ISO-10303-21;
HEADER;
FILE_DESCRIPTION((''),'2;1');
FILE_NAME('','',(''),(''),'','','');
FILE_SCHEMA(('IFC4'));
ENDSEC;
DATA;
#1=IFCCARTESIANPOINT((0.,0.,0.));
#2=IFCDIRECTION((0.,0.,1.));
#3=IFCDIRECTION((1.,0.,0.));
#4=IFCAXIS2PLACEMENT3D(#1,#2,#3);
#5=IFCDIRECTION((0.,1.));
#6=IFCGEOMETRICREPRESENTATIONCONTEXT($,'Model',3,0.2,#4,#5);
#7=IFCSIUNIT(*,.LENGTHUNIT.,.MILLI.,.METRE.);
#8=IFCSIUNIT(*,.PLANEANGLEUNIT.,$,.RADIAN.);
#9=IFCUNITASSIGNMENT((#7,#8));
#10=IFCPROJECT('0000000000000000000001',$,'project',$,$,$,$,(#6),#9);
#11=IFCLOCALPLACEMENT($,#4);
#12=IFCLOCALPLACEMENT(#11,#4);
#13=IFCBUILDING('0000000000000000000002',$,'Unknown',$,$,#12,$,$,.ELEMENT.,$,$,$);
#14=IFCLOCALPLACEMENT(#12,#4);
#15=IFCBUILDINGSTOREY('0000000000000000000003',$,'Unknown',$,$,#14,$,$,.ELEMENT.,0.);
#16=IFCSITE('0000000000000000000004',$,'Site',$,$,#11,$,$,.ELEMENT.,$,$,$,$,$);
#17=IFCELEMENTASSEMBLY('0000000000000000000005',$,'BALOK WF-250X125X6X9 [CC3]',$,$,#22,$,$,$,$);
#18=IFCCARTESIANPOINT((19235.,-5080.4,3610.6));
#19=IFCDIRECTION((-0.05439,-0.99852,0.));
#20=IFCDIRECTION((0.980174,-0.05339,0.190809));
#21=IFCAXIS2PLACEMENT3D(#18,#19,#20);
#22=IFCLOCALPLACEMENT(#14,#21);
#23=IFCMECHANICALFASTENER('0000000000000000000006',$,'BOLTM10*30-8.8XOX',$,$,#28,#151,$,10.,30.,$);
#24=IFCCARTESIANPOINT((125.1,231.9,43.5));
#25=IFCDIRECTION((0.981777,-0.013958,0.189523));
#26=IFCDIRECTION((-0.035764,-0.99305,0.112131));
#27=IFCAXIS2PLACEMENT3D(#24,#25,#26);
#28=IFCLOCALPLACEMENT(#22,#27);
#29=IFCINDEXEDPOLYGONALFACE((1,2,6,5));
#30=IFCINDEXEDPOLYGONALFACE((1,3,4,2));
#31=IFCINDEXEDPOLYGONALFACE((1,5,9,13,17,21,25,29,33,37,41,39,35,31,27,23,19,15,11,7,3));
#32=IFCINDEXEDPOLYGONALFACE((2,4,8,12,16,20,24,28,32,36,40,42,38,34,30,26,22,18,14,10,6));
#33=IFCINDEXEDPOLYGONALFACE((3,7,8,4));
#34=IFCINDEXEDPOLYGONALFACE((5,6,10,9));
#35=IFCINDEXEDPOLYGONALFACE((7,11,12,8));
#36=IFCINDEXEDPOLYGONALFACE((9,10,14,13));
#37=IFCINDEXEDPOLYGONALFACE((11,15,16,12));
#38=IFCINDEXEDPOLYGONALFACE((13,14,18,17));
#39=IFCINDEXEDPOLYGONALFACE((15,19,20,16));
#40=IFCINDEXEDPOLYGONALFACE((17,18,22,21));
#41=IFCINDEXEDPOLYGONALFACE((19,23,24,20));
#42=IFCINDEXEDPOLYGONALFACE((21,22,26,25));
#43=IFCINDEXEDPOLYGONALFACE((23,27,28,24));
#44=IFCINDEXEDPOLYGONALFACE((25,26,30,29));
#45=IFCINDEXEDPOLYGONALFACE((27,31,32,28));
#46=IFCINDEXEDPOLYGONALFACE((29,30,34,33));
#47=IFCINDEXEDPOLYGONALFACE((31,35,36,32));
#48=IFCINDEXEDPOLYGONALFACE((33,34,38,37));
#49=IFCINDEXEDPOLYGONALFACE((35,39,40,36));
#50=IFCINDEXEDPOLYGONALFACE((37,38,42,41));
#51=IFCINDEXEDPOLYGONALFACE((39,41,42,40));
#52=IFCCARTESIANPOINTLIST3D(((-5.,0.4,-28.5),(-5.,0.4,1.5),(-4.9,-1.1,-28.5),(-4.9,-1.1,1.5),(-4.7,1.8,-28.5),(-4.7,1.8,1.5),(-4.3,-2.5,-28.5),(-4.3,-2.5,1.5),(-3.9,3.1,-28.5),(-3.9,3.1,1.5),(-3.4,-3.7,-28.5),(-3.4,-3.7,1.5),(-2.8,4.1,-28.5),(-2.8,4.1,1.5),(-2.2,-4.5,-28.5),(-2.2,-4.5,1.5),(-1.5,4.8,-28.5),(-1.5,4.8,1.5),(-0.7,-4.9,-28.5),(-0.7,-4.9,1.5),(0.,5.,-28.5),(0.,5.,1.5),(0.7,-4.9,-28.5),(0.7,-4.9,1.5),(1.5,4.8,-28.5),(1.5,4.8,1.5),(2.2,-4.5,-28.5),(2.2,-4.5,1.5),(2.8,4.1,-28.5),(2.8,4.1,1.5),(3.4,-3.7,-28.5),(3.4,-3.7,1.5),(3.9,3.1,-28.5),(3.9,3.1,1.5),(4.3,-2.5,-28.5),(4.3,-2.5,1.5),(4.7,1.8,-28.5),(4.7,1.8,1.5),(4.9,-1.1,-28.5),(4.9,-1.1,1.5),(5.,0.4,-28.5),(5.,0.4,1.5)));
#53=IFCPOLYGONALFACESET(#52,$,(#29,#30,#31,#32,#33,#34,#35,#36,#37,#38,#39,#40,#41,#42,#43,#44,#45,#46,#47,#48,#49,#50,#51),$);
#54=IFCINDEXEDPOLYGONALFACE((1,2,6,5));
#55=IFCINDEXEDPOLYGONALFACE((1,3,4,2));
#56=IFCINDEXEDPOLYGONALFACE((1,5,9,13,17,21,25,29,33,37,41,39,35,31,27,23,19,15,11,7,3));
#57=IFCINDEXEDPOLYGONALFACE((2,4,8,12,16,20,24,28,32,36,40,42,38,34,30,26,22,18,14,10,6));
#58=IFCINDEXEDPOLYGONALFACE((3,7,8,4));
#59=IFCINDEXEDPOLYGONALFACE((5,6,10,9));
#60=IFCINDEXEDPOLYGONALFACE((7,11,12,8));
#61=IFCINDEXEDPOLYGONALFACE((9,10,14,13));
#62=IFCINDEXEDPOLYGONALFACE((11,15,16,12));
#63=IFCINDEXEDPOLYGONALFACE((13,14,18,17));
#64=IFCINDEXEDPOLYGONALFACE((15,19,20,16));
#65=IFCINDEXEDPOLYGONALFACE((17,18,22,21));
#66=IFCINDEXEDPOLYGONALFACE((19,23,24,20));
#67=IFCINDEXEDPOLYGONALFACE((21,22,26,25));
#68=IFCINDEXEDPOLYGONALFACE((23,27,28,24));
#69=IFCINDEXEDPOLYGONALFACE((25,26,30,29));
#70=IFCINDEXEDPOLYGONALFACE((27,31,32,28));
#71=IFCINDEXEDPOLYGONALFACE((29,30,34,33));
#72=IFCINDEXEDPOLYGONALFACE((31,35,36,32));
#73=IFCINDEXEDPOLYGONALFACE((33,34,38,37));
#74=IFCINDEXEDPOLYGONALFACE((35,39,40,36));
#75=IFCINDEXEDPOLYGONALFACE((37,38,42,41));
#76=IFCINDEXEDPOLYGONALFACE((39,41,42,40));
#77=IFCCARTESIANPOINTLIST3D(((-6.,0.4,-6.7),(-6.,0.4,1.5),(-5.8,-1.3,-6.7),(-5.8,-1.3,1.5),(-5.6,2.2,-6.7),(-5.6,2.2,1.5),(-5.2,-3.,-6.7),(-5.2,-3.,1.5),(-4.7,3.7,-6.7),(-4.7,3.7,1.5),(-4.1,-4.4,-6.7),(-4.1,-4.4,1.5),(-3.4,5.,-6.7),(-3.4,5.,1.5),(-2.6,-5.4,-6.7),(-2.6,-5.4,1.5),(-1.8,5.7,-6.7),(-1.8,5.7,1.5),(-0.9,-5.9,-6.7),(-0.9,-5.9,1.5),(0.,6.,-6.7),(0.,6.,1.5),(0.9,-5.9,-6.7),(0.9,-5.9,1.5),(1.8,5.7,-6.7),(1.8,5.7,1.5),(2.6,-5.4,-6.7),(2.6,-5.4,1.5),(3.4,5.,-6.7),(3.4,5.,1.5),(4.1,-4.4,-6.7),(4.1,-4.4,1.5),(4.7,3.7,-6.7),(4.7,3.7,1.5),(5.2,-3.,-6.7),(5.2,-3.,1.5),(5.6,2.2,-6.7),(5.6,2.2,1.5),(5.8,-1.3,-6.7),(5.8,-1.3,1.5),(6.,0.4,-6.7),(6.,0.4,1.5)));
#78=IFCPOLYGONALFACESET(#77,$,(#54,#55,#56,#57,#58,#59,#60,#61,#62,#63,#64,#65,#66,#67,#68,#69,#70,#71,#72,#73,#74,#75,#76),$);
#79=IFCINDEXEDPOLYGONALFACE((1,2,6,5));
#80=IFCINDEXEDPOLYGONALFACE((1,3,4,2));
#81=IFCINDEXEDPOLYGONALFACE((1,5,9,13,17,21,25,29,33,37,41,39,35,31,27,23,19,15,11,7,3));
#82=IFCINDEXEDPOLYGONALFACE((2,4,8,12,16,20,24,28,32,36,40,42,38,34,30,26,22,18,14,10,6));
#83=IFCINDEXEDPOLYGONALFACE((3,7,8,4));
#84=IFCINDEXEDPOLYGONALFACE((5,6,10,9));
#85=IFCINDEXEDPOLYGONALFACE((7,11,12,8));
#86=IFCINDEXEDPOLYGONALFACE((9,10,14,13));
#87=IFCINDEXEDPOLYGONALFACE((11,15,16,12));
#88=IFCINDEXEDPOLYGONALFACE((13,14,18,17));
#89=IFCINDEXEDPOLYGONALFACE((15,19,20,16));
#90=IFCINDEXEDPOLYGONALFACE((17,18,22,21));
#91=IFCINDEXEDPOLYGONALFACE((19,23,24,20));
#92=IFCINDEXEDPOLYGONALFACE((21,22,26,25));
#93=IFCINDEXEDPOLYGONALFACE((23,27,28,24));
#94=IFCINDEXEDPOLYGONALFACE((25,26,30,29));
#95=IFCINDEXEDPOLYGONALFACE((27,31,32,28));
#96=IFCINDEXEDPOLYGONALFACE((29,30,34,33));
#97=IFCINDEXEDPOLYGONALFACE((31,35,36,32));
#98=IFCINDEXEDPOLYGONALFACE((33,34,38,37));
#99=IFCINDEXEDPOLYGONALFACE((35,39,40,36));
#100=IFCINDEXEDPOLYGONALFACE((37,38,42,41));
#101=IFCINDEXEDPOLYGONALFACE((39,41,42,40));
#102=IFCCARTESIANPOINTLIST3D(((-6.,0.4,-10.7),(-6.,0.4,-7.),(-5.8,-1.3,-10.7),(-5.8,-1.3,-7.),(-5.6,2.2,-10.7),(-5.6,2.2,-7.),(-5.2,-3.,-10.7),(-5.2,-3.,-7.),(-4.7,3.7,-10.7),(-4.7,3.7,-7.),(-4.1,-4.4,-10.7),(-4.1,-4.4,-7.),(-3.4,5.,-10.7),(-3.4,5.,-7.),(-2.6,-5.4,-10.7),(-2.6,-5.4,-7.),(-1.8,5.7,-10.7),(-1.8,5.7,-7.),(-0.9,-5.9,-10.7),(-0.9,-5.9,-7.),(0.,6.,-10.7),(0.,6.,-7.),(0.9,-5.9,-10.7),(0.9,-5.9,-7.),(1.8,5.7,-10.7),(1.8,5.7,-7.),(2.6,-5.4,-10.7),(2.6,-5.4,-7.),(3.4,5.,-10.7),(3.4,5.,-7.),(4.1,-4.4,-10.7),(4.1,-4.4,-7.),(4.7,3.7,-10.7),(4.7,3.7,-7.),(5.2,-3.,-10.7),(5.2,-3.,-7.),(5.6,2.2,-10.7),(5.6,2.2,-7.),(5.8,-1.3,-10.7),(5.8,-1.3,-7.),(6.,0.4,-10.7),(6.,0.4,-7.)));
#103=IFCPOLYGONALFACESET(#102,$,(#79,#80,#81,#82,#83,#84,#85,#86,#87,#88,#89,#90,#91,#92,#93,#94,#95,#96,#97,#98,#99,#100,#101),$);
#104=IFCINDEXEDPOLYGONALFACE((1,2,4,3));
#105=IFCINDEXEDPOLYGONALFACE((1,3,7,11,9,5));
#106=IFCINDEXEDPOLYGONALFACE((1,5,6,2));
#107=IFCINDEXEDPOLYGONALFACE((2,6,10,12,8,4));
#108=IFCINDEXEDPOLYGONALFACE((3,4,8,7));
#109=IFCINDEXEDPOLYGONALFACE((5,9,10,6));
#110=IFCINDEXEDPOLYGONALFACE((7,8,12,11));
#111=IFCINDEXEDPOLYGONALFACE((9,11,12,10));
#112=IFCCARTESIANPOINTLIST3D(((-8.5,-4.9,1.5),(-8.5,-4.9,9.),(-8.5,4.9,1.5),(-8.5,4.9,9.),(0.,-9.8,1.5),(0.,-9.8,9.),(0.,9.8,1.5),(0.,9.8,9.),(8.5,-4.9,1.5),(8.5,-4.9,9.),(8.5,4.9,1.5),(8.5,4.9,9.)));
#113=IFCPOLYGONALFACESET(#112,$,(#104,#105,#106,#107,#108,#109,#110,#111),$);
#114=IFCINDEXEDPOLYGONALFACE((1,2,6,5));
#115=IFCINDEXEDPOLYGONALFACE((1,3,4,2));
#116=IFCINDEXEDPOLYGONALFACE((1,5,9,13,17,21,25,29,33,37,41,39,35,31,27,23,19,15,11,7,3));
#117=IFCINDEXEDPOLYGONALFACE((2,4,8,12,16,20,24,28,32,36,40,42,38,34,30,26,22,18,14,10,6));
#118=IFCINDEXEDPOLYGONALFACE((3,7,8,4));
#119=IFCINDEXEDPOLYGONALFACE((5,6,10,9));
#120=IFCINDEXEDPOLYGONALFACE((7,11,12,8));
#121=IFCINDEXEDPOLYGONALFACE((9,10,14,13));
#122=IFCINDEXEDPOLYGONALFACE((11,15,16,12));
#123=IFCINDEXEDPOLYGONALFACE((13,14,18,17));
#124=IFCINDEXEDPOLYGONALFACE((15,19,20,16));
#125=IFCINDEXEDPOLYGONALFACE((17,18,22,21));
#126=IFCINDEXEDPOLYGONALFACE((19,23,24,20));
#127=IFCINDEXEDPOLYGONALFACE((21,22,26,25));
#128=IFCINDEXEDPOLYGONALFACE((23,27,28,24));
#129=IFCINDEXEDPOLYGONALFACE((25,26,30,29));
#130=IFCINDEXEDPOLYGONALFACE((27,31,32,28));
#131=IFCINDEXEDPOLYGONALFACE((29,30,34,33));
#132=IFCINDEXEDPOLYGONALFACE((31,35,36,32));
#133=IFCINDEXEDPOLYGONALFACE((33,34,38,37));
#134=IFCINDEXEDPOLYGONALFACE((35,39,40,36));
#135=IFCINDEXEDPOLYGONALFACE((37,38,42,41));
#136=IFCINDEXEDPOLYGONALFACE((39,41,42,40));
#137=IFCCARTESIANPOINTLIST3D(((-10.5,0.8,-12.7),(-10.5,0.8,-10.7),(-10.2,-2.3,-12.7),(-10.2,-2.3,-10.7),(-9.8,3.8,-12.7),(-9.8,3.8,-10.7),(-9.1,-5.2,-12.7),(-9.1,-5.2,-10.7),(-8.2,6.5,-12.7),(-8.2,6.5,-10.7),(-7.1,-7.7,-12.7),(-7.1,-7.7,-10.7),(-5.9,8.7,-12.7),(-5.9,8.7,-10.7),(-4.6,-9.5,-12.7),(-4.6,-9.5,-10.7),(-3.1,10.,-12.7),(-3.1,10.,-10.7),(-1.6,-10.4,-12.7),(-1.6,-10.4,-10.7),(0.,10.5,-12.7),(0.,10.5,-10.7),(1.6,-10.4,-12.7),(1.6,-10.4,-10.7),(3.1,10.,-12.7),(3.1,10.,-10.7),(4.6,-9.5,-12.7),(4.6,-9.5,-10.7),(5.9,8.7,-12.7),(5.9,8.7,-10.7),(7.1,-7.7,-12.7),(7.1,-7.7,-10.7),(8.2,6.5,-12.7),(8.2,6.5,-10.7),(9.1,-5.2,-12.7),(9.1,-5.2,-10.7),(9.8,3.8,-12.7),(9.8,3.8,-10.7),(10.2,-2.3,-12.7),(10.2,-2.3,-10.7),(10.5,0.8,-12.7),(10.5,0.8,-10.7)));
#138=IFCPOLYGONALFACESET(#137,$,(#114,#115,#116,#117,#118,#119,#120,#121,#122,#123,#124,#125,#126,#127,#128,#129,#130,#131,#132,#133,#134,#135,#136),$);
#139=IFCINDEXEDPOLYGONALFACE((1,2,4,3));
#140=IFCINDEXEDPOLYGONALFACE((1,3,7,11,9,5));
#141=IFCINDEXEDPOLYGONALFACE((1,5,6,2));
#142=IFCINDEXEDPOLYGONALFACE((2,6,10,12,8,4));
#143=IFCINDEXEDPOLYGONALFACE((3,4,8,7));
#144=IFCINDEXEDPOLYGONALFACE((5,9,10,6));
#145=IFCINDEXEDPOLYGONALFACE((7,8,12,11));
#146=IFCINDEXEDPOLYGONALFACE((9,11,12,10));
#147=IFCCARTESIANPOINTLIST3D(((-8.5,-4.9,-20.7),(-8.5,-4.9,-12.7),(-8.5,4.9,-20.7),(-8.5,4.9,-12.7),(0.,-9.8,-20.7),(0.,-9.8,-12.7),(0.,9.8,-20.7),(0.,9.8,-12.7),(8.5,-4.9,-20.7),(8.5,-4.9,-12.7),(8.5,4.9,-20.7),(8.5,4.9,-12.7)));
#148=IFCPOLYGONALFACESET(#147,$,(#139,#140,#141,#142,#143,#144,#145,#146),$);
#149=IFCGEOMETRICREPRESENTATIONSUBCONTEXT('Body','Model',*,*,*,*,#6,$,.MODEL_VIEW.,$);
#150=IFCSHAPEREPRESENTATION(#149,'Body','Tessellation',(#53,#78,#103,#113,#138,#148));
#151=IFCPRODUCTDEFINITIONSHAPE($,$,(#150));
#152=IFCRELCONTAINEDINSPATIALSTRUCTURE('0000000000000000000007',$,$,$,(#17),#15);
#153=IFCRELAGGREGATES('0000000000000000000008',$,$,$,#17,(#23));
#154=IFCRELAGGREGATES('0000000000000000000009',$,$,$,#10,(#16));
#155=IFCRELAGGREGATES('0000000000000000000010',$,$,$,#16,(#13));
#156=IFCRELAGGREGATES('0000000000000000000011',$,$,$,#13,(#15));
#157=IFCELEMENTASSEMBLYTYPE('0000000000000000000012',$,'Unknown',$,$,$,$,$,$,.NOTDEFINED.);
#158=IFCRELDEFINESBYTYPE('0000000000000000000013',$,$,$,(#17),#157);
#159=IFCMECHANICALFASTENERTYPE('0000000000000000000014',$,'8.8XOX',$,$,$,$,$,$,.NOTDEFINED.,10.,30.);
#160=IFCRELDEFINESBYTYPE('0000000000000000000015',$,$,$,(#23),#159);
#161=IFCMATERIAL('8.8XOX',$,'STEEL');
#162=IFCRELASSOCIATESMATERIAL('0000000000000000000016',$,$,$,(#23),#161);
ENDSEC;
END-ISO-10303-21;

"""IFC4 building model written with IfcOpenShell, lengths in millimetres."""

from ifc_helpers import new_model, si_unit, direction, frame, origin_with_axes, origin_2d_with_axis, place, context, subcontext, project, spatial, polyline, circle, outline, extrude, source, transform, mapped, material, type_object, element, aggregate, save


model = new_model("IFC4")

# Units and contexts
model_context = context("Model", 3, precision=0.2, world=origin_with_axes(), true_north=direction((0.0, 1.0)))
body_context = subcontext(model_context, "Body", "Model", "MODEL_VIEW")
ifc_project = project(units=[si_unit("LENGTHUNIT", "METRE", prefix="MILLI"), si_unit("PLANEANGLEUNIT", "RADIAN")], contexts=[model_context])

# Site, building, storey
site_placement = place(None, origin_with_axes())
site = spatial("IfcSite", under=ifc_project, at=site_placement, Name="Site", CompositionType="ELEMENT")
building_placement = place(site_placement, origin_with_axes())
building = spatial("IfcBuilding", under=site, at=building_placement, Name="Unknown", CompositionType="ELEMENT")
storey_placement = place(building_placement, origin_with_axes())
storey = spatial("IfcBuildingStorey", under=building, at=storey_placement, Name="Unknown", CompositionType="ELEMENT", Elevation=0.0)

# Element assembly
element_assembly_type = type_object("IfcElementAssemblyType", Name="Unknown", PredefinedType="NOTDEFINED")
assembly_1_placement = place(storey_placement, frame((19235.0, -5080.4, 3610.6), z_axis=(-0.05439, -0.99852, 0.0), x_axis=(0.980174, -0.05339, 0.190809)))
assembly_1 = element("IfcElementAssembly", 1, at=assembly_1_placement, inside=storey, type_object=element_assembly_type, Name="BALOK WF-250X125X6X9 [CC3]")

# Mechanical fastener
ifc_material_1 = material(Name="8.8XOX", Category="STEEL")
mechanical_fastener_type_1 = type_object("IfcMechanicalFastenerType", Name="8.8XOX", NominalDiameter=10.0, NominalLength=30.0, PredefinedType="NOTDEFINED")
shared_shape_1 = source(origin_with_axes(), body_context, "Body", "SweptSolid", [
    extrude(circle(Radius=5.0, at=origin_2d_with_axis()), frame((0.0, 0.0, 1.5), z_axis=(0.0, 0.0, -1.0), x_axis=(0.0, 1.0, 0.0)), (0.0, 0.0, 1.0), 30.0),
    extrude(circle(Radius=6.0, at=origin_2d_with_axis()), frame((0.0, 0.0, 1.5), z_axis=(0.0, 0.0, -1.0), x_axis=(0.0, 1.0, 0.0)), (0.0, 0.0, 1.0), 8.3),
    extrude(circle(Radius=6.0, at=origin_2d_with_axis()), frame((0.0, 0.0, -7.0), z_axis=(0.0, 0.0, -1.0), x_axis=(0.0, 1.0, 0.0)), (0.0, 0.0, 1.0), 3.7),
    extrude(outline(polyline([(9.8, 0.0), (4.9, 8.5), (-4.9, 8.5), (-9.8, 0.0), (-4.9, -8.5), (4.9, -8.5), (9.8, 0.0)])), frame((0.0, 0.0, 9.0), z_axis=(0.0, 0.0, -1.0), x_axis=(0.0, 1.0, 0.0)), (0.0, 0.0, 1.0), 7.5),
    extrude(circle(Radius=10.5, at=origin_2d_with_axis()), frame((0.0, 0.0, -10.7), z_axis=(0.0, 0.0, -1.0), x_axis=(0.0, 1.0, 0.0)), (0.0, 0.0, 1.0), 2.0),
    extrude(outline(polyline([(9.8, 0.0), (4.9, 8.5), (-4.9, 8.5), (-9.8, 0.0), (-4.9, -8.5), (4.9, -8.5), (9.8, 0.0)])), frame((0.0, 0.0, -12.7), z_axis=(0.0, 0.0, -1.0), x_axis=(0.0, 1.0, 0.0)), (0.0, 0.0, 1.0), 8.0),
])
mechanical_fastener_1_placement = place(assembly_1_placement, frame((125.1, 231.9, 43.5), z_axis=(0.981777, -0.013958, 0.189523), x_axis=(-0.035764, -0.99305, 0.112131)))
mechanical_fastener_1 = element("IfcMechanicalFastener", 2, at=mechanical_fastener_1_placement, type_object=mechanical_fastener_type_1, material=ifc_material_1, Name="BOLTM10*30-8.8XOX", NominalDiameter=10.0, NominalLength=30.0, context=body_context, shape_type="MappedRepresentation", body=[
    mapped(shared_shape_1, transform((0.0, 0.0, 0.0))),
])
aggregate(assembly_1, [mechanical_fastener_1])

save(model, "model.ifc")
